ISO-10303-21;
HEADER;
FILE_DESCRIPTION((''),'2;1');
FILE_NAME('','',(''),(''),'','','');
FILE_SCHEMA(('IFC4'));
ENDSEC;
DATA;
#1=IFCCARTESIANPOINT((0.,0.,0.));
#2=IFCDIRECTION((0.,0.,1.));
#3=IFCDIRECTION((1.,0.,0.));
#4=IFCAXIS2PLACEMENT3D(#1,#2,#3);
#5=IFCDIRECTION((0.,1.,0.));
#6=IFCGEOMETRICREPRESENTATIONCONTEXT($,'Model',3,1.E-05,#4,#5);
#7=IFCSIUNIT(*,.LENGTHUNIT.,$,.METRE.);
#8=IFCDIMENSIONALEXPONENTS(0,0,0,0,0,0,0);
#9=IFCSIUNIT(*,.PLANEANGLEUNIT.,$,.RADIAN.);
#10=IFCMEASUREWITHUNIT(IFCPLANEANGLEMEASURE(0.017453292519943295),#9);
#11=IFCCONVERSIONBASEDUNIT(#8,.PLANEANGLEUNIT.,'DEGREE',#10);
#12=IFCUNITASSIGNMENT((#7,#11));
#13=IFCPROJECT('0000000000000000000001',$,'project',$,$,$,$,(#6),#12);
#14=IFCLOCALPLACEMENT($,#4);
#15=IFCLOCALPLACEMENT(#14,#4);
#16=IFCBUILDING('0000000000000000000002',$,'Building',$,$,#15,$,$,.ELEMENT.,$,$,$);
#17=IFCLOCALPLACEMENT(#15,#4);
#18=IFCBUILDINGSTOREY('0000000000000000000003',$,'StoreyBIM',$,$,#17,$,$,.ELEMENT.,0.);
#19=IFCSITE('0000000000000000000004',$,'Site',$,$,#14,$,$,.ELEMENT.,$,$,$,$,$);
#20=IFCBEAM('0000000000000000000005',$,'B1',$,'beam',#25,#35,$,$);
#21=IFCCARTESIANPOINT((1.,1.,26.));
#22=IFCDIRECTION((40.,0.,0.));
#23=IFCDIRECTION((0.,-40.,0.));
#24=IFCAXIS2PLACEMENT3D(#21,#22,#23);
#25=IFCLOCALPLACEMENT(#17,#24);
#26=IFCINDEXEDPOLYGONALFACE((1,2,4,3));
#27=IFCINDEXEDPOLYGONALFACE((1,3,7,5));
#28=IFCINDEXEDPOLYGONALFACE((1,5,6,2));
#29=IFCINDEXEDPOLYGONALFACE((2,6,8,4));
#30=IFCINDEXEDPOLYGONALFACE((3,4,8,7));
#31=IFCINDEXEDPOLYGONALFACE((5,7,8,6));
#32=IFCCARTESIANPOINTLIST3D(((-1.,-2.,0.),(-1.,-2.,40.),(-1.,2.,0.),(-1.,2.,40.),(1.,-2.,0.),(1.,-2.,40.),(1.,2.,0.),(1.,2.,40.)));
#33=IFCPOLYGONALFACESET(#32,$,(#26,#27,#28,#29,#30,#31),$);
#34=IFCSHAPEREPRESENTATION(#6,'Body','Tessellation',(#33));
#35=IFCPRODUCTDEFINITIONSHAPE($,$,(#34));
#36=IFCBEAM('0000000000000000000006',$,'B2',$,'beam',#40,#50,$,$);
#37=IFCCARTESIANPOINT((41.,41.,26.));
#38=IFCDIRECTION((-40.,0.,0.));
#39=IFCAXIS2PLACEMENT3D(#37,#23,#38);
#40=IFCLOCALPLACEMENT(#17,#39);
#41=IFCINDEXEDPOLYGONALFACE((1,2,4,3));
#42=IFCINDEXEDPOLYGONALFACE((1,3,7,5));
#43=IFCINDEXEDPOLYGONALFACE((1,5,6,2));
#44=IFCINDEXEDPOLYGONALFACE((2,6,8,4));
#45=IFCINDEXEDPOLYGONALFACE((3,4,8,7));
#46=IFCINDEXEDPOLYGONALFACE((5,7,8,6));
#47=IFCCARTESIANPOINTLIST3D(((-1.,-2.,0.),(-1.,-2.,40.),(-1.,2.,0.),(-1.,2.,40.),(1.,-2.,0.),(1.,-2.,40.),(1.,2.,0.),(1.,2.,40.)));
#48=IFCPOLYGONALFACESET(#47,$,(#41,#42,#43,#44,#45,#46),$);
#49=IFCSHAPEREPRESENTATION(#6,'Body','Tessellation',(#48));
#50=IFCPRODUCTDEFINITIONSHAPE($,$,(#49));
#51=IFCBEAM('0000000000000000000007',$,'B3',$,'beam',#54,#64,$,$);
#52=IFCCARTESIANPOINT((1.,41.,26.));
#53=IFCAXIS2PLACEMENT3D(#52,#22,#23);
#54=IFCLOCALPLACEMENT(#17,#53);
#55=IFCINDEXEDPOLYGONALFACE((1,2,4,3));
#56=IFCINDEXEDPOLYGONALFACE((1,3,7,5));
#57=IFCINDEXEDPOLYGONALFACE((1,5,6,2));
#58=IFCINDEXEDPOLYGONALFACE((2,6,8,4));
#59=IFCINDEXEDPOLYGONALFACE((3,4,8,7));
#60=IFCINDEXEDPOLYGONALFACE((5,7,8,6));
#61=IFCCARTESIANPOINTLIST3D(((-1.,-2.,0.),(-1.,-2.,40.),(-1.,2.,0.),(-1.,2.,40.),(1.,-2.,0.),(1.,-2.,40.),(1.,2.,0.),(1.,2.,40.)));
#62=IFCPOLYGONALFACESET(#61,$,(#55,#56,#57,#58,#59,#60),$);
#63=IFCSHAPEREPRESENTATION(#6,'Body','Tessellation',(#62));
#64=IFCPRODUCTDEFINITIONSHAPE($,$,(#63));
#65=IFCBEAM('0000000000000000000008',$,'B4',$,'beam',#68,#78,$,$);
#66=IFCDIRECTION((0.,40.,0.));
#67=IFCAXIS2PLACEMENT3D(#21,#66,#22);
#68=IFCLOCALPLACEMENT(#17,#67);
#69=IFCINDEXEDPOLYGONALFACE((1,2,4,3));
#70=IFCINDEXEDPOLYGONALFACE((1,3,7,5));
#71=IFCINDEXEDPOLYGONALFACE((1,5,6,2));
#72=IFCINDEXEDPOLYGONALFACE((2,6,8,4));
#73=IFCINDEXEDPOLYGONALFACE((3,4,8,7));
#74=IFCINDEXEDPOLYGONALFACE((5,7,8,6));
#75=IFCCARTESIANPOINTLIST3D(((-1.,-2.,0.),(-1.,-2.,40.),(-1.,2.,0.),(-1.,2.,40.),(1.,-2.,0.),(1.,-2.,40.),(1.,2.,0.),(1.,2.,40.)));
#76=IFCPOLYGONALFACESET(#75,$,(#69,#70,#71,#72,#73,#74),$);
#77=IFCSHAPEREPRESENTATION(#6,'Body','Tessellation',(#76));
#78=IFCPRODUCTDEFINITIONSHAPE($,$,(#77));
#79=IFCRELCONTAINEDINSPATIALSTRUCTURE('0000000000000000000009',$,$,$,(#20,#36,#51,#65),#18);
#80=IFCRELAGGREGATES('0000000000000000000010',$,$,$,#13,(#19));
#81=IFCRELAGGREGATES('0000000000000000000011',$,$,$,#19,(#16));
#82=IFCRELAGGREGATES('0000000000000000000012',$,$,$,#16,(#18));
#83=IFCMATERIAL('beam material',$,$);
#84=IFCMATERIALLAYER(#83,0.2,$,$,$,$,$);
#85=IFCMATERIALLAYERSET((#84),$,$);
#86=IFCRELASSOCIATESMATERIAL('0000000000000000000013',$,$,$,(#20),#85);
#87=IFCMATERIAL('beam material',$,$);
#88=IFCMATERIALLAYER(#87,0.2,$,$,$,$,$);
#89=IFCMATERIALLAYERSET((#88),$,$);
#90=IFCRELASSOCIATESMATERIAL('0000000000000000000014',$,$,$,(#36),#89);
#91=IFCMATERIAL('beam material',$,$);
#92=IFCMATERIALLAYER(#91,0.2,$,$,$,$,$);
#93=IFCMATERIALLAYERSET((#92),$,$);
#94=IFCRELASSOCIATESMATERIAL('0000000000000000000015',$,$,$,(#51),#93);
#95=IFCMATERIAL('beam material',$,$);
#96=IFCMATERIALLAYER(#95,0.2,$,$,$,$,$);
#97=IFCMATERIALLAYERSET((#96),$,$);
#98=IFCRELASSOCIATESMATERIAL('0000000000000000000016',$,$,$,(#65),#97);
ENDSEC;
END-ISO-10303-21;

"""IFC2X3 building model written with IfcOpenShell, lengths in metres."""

from ifc_helpers import new_model, entity, si_unit, converted_unit, direction, frame, origin, origin_with_axes, origin_2d, place, context, project, spatial, rectangle, extrude, material, layer, layer_set, layer_usage, element, save


model = new_model("IFC2X3")

# Units and contexts
model_context = context("Model", 3, precision=1e-05, world=origin_with_axes(), true_north=direction((0.0, 1.0, 0.0)))
ifc_project = project(units=[si_unit("LENGTHUNIT", "METRE"), converted_unit("PLANEANGLEUNIT", "DEGREE", entity("IfcPlaneAngleMeasure", 0.017453292519943295), si_unit("PLANEANGLEUNIT", "RADIAN"), dimensions=[0, 0, 0, 0, 0, 0, 0])], contexts=[model_context])

# Site, building, storey
site_placement = place(None, origin_with_axes())
site = spatial("IfcSite", under=ifc_project, at=site_placement, Name="Site", CompositionType="ELEMENT")
building_placement = place(site_placement, origin_with_axes())
building = spatial("IfcBuilding", under=site, at=building_placement, Name="Building", CompositionType="ELEMENT")
storey_placement = place(building_placement, origin_with_axes())
storey = spatial("IfcBuildingStorey", under=building, at=storey_placement, Name="StoreyBIM", CompositionType="ELEMENT", Elevation=0.0)

# Beams
ifc_material_1 = material(Name="beam material")
ifc_layer_1 = layer(ifc_material_1, 0.2)
ifc_layer_set_1 = layer_set([ifc_layer_1])
ifc_layer_usage_1 = layer_usage(ifc_layer_set_1, "AXIS2", "POSITIVE", -0.1)
beam_1_placement = place(storey_placement, frame((1.0, 1.0, 26.0), z_axis=(40.0, 0.0, 0.0), x_axis=(0.0, -40.0, 0.0)))
element("IfcBeam", 1, at=beam_1_placement, inside=storey, material=ifc_layer_usage_1, Name="B1", ObjectType="beam", context=model_context, shape_type="SweptSolid", body=[
    extrude(rectangle(XDim=2.0, YDim=4.0, at=origin_2d()), origin(), (0.0, 0.0, 1.0), 40.0),
])
ifc_material_2 = material(Name="beam material")
ifc_layer_2 = layer(ifc_material_2, 0.2)
ifc_layer_set_2 = layer_set([ifc_layer_2])
ifc_layer_usage_2 = layer_usage(ifc_layer_set_2, "AXIS2", "POSITIVE", -0.1)
beam_2_placement = place(storey_placement, frame((41.0, 41.0, 26.0), z_axis=(0.0, -40.0, 0.0), x_axis=(-40.0, 0.0, 0.0)))
element("IfcBeam", 2, at=beam_2_placement, inside=storey, material=ifc_layer_usage_2, Name="B2", ObjectType="beam", context=model_context, shape_type="SweptSolid", body=[
    extrude(rectangle(XDim=2.0, YDim=4.0, at=origin_2d()), origin(), (0.0, 0.0, 1.0), 40.0),
])
ifc_material_3 = material(Name="beam material")
ifc_layer_3 = layer(ifc_material_3, 0.2)
ifc_layer_set_3 = layer_set([ifc_layer_3])
ifc_layer_usage_3 = layer_usage(ifc_layer_set_3, "AXIS2", "POSITIVE", -0.1)
beam_3_placement = place(storey_placement, frame((1.0, 41.0, 26.0), z_axis=(40.0, 0.0, 0.0), x_axis=(0.0, -40.0, 0.0)))
element("IfcBeam", 3, at=beam_3_placement, inside=storey, material=ifc_layer_usage_3, Name="B3", ObjectType="beam", context=model_context, shape_type="SweptSolid", body=[
    extrude(rectangle(XDim=2.0, YDim=4.0, at=origin_2d()), origin(), (0.0, 0.0, 1.0), 40.0),
])
ifc_material_4 = material(Name="beam material")
ifc_layer_4 = layer(ifc_material_4, 0.2)
ifc_layer_set_4 = layer_set([ifc_layer_4])
ifc_layer_usage_4 = layer_usage(ifc_layer_set_4, "AXIS2", "POSITIVE", -0.1)
beam_4_placement = place(storey_placement, frame((1.0, 1.0, 26.0), z_axis=(0.0, 40.0, 0.0), x_axis=(40.0, 0.0, 0.0)))
element("IfcBeam", 4, at=beam_4_placement, inside=storey, material=ifc_layer_usage_4, Name="B4", ObjectType="beam", context=model_context, shape_type="SweptSolid", body=[
    extrude(rectangle(XDim=2.0, YDim=4.0, at=origin_2d()), origin(), (0.0, 0.0, 1.0), 40.0),
])

save(model, "model.ifc")
